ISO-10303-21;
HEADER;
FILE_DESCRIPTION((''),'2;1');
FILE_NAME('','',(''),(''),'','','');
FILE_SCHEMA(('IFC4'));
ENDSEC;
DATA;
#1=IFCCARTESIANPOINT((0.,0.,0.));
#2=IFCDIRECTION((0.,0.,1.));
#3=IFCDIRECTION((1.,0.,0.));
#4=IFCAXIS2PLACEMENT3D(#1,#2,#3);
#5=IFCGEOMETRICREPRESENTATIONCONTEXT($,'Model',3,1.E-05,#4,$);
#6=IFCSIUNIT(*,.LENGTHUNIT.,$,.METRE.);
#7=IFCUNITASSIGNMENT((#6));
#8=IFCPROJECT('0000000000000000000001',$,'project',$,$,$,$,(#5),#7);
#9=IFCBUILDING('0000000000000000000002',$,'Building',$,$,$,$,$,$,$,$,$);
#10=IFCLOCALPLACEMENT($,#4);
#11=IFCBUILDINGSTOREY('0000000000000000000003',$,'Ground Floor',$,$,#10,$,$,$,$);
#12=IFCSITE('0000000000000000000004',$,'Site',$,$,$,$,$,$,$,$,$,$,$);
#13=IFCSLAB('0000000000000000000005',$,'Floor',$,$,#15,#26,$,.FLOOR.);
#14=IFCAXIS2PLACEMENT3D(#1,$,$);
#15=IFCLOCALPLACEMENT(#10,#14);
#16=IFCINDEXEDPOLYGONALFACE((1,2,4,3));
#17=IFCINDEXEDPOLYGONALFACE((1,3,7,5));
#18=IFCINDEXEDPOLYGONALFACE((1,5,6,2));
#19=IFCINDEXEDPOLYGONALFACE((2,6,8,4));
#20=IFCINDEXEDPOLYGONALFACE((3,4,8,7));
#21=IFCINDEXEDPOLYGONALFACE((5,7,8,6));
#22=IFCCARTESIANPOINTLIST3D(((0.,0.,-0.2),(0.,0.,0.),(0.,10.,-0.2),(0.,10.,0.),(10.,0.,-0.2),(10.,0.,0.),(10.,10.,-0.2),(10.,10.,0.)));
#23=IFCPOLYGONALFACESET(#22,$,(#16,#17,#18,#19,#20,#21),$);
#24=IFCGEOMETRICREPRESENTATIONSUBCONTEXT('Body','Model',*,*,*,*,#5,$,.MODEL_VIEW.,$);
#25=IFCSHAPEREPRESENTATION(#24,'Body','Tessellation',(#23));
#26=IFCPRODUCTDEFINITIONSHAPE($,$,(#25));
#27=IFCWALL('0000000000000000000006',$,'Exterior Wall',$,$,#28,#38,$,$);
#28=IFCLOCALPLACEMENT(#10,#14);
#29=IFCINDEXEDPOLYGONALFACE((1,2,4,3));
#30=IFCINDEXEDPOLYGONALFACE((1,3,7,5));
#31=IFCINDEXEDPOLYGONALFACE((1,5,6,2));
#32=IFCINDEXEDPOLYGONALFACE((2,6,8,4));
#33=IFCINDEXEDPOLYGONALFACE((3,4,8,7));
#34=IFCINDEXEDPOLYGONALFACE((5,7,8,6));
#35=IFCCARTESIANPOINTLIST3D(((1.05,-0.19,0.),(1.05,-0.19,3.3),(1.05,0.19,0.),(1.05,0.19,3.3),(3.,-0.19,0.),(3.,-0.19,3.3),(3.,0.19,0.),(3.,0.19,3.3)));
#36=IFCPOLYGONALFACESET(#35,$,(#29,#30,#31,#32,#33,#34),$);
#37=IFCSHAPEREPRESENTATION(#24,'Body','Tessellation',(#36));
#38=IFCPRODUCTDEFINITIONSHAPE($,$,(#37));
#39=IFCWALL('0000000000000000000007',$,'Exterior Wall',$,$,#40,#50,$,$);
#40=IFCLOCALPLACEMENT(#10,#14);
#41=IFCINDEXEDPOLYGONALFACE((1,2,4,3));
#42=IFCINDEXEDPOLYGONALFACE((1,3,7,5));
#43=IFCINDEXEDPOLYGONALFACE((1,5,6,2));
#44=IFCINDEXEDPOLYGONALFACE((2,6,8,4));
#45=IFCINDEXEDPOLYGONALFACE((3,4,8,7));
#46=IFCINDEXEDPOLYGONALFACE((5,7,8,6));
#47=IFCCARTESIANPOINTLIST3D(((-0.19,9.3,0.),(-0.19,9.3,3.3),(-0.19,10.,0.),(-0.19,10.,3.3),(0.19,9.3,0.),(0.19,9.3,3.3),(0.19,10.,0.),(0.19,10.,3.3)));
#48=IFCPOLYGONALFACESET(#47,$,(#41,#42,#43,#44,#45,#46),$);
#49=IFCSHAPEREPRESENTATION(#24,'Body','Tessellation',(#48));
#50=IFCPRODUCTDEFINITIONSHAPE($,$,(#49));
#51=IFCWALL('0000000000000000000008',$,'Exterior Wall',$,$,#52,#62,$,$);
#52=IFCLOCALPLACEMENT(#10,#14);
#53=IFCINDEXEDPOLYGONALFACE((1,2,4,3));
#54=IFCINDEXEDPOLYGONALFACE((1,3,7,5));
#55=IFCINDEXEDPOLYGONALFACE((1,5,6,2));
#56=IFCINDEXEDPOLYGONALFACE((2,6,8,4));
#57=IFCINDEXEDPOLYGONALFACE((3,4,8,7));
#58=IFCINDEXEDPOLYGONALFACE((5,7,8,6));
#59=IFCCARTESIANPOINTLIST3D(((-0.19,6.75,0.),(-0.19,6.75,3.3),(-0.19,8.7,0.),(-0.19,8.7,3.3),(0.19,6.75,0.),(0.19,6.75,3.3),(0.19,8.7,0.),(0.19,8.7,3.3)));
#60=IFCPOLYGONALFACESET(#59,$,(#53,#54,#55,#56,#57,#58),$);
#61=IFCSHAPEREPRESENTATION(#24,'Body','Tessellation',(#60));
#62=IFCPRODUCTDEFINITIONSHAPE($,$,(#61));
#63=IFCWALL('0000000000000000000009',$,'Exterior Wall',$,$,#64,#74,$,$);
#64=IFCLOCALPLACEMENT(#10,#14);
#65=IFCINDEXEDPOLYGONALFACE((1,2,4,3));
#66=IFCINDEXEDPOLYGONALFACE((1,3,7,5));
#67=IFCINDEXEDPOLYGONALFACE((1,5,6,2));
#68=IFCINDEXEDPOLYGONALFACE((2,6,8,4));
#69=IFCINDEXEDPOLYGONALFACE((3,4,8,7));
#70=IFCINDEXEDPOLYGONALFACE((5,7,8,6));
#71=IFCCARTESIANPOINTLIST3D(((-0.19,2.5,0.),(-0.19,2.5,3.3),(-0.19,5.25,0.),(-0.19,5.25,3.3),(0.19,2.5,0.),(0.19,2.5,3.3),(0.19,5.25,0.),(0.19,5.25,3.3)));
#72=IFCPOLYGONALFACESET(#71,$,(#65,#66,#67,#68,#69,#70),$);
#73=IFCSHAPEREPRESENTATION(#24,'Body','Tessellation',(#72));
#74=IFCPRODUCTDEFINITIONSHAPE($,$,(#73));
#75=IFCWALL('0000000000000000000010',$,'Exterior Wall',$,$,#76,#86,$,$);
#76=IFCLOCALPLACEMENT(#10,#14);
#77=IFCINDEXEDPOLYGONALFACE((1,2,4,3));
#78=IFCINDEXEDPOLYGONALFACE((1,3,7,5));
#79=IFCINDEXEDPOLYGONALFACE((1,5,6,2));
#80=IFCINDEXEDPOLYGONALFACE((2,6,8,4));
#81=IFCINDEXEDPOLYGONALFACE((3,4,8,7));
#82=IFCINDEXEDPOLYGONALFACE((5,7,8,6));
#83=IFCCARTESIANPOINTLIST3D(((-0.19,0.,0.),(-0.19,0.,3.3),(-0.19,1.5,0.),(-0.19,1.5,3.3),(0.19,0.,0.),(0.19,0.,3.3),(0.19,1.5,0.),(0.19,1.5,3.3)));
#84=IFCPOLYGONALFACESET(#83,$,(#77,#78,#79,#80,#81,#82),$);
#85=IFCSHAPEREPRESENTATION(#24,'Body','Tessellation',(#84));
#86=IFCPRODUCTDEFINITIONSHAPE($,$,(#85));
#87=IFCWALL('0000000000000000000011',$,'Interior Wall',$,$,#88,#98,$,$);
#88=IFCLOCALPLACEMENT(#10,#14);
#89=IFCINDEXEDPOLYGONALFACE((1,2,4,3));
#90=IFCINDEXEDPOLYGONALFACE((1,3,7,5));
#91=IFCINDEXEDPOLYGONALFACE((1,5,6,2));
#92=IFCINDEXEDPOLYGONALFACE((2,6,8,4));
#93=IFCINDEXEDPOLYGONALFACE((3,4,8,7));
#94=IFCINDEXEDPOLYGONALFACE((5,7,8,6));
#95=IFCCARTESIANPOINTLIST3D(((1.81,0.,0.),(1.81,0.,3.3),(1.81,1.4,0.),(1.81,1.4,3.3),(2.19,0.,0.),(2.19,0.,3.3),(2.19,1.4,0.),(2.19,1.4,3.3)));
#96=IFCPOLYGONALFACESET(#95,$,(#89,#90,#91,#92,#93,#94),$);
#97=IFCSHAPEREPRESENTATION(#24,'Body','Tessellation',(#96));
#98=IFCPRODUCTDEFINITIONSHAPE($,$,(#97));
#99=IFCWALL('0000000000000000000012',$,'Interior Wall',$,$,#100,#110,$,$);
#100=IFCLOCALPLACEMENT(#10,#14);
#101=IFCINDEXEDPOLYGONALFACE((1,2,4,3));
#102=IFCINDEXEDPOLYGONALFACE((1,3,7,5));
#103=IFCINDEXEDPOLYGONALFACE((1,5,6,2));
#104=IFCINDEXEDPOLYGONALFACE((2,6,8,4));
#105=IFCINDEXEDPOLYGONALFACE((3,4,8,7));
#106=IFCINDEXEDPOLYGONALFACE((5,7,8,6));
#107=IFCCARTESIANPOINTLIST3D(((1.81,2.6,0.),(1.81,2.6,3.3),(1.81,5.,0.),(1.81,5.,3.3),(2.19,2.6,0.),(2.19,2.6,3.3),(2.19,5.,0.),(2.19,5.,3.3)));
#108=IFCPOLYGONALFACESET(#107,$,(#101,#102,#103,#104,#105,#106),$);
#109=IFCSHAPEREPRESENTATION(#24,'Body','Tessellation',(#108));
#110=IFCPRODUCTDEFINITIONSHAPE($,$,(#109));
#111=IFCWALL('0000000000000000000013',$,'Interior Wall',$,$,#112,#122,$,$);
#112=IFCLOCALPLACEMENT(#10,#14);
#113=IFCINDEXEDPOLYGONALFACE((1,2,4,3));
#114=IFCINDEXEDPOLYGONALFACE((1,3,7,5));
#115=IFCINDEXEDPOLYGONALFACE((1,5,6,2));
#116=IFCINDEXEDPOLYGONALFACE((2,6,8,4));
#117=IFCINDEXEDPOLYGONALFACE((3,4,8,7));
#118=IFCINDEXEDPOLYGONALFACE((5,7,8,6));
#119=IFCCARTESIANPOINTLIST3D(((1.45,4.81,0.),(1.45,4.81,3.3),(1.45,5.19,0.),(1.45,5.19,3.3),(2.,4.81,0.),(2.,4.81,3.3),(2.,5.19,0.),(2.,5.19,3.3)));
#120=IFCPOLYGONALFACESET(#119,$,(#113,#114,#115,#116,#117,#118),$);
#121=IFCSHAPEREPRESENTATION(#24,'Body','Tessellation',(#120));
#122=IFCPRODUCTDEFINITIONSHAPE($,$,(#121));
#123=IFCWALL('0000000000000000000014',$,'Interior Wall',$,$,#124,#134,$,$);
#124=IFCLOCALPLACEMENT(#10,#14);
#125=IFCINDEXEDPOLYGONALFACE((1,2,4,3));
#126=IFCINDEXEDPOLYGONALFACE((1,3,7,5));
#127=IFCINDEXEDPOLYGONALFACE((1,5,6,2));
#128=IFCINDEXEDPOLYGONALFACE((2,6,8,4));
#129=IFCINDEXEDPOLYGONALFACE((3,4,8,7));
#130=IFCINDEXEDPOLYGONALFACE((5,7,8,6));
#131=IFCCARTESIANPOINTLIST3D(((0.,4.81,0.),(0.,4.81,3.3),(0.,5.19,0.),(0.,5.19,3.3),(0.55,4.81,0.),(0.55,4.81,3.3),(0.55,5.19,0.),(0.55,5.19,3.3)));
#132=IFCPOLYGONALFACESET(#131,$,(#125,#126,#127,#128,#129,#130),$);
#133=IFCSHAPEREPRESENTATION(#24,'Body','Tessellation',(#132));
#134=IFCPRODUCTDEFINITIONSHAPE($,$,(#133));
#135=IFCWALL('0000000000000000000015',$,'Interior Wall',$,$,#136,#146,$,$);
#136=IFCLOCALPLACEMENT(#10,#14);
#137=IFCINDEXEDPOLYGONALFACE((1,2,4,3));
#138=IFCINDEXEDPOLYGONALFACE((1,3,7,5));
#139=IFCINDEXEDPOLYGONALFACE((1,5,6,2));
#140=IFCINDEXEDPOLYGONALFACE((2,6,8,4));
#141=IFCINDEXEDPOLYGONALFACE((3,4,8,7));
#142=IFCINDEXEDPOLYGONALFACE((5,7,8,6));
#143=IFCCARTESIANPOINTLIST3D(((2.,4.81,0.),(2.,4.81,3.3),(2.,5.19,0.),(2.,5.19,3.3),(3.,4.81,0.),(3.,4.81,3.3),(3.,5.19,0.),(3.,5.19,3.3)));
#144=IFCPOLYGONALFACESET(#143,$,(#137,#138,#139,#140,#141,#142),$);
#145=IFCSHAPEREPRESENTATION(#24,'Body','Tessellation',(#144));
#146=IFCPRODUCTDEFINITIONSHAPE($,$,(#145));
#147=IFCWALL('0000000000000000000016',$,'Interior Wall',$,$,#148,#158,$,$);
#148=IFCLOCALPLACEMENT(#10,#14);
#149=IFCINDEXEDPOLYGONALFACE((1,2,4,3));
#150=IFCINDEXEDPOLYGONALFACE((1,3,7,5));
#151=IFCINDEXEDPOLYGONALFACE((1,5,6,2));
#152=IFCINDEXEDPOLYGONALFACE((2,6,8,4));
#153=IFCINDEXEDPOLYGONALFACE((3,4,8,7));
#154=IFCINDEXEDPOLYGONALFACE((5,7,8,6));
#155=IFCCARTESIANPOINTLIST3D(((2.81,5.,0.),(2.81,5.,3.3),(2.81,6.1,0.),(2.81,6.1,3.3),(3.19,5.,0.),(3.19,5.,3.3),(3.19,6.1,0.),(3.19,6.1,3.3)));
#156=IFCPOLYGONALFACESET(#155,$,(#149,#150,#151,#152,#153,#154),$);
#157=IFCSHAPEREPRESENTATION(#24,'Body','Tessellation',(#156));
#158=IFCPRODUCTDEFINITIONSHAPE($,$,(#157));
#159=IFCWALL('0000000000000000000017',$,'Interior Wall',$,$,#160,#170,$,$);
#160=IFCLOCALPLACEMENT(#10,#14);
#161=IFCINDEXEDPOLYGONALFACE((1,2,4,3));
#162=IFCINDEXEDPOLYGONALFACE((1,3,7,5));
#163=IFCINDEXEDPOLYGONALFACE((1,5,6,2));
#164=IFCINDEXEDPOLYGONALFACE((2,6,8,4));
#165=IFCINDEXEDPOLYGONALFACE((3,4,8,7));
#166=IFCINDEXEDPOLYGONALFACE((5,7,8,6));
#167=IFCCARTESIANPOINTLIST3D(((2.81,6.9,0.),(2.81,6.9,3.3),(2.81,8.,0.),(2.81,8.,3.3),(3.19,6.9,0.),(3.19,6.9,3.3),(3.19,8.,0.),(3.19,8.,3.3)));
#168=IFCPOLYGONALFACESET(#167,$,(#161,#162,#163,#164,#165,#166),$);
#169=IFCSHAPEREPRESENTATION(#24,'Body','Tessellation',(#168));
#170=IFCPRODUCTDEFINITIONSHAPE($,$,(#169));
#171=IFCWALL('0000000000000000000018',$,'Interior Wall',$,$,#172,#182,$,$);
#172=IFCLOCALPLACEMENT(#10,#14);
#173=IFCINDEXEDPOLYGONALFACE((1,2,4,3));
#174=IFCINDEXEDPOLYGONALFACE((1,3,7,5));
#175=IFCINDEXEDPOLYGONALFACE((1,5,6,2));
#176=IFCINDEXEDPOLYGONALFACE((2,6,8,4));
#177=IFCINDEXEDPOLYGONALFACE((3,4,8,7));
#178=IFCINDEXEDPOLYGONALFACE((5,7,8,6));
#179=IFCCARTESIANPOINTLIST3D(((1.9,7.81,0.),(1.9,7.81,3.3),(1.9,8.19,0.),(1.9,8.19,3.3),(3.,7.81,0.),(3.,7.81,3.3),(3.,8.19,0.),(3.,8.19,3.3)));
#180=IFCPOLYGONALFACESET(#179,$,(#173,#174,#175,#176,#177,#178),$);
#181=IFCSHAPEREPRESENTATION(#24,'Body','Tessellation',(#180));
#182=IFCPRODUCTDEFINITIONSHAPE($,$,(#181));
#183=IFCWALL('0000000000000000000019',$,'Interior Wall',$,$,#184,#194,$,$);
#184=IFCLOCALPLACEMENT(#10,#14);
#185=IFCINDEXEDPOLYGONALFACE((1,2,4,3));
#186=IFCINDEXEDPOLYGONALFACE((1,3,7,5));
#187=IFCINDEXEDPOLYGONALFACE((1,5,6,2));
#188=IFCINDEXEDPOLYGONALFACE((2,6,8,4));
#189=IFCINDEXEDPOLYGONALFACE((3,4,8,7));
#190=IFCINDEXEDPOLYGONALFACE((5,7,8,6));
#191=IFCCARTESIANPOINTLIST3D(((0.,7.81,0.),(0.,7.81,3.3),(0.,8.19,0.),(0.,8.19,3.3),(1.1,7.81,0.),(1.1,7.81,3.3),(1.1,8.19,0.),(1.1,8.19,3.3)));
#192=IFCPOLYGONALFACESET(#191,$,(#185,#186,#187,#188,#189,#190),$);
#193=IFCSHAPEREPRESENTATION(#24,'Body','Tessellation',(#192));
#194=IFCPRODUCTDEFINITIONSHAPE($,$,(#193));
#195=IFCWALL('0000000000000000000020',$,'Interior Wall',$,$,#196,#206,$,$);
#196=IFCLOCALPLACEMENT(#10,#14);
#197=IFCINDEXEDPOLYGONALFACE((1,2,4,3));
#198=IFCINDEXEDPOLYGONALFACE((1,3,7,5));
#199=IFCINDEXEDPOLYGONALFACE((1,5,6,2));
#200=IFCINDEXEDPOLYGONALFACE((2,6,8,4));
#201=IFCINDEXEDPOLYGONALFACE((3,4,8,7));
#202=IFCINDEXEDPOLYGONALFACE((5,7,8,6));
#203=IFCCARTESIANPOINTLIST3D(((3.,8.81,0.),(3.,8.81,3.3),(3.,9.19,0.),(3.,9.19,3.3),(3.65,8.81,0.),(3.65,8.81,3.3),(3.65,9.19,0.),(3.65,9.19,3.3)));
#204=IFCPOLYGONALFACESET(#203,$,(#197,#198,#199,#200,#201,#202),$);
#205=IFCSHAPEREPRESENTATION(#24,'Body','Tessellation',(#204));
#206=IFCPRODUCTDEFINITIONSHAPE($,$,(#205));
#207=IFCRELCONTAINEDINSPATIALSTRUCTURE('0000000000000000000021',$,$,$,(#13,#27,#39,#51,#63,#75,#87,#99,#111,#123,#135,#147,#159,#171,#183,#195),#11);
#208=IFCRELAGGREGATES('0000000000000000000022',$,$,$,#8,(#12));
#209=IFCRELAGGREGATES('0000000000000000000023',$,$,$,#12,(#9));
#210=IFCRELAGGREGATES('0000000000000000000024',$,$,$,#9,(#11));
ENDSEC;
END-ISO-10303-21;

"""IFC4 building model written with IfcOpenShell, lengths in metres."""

from ifc_helpers import new_model, si_unit, frame, origin_with_axes, place, context, subcontext, project, spatial, indexed_curve, outline, extrude, element, save


model = new_model("IFC4")

# Units and contexts
model_context = context("Model", 3, precision=1e-05, world=origin_with_axes())
body_context = subcontext(model_context, "Body", "Model", "MODEL_VIEW")
ifc_project = project(units=[si_unit("LENGTHUNIT", "METRE")], contexts=[model_context])

# Site, building, storey
site = spatial("IfcSite", under=ifc_project, Name="Site")
building = spatial("IfcBuilding", under=site, Name="Building")
storey_placement = place(None, origin_with_axes())
storey = spatial("IfcBuildingStorey", under=building, at=storey_placement, Name="Ground Floor")

# Slab
slab_placement = place(storey_placement, frame((0.0, 0.0, -0.2), z_axis=(0.0, 0.0, 1.0), x_axis=(1.0, 0.0, 0.0)))
element("IfcSlab", 1, at=slab_placement, inside=storey, Name="Floor", PredefinedType="FLOOR", context=body_context, shape_type="SweptSolid", body=[
    extrude(outline(indexed_curve([(0.0, 0.0), (10.0, 0.0), (10.0, 10.0), (0.0, 10.0)])), None, (0.0, 0.0, 1.0), 0.2),
])

# Walls
wall_1_placement = place(storey_placement, frame((1.05, 0.0, 0.0), z_axis=(0.0, 0.0, 1.0), x_axis=(1.0, 0.0, 0.0)))
element("IfcWall", 2, at=wall_1_placement, inside=storey, Name="Exterior Wall", context=body_context, shape_type="SweptSolid", body=[
    extrude(outline(indexed_curve([(0.0, 0.0), (0.0, 0.38), (1.95, 0.38), (1.95, 0.0), (0.0, 0.0)], self_intersect=False)), frame((0.0, -0.19, 0.0), z_axis=(0.0, 0.0, 1.0), x_axis=(1.0, 0.0, 0.0)), (0.0, 0.0, 1.0), 3.3),
])
wall_2_placement = place(storey_placement, frame((0.0, 10.0, 0.0), z_axis=(0.0, 0.0, 1.0), x_axis=(0.0, -1.0, 0.0)))
element("IfcWall", 3, at=wall_2_placement, inside=storey, Name="Exterior Wall", context=body_context, shape_type="SweptSolid", body=[
    extrude(outline(indexed_curve([(0.0, 0.0), (0.0, 0.38), (0.7, 0.38), (0.7, 0.0), (0.0, 0.0)], self_intersect=False)), frame((0.0, -0.19, 0.0), z_axis=(0.0, 0.0, 1.0), x_axis=(1.0, 0.0, 0.0)), (0.0, 0.0, 1.0), 3.3),
])
wall_3_placement = place(storey_placement, frame((0.0, 8.7, 0.0), z_axis=(0.0, 0.0, 1.0), x_axis=(0.0, -1.0, 0.0)))
element("IfcWall", 4, at=wall_3_placement, inside=storey, Name="Exterior Wall", context=body_context, shape_type="SweptSolid", body=[
    extrude(outline(indexed_curve([(0.0, 0.0), (0.0, 0.38), (1.95, 0.38), (1.95, 0.0), (0.0, 0.0)], self_intersect=False)), frame((0.0, -0.19, 0.0), z_axis=(0.0, 0.0, 1.0), x_axis=(1.0, 0.0, 0.0)), (0.0, 0.0, 1.0), 3.3),
])
wall_4_placement = place(storey_placement, frame((0.0, 5.25, 0.0), z_axis=(0.0, 0.0, 1.0), x_axis=(0.0, -1.0, 0.0)))
element("IfcWall", 5, at=wall_4_placement, inside=storey, Name="Exterior Wall", context=body_context, shape_type="SweptSolid", body=[
    extrude(outline(indexed_curve([(0.0, 0.0), (0.0, 0.38), (2.75, 0.38), (2.75, 0.0), (0.0, 0.0)], self_intersect=False)), frame((0.0, -0.19, 0.0), z_axis=(0.0, 0.0, 1.0), x_axis=(1.0, 0.0, 0.0)), (0.0, 0.0, 1.0), 3.3),
])
wall_5_placement = place(storey_placement, frame((0.0, 1.5, 0.0), z_axis=(0.0, 0.0, 1.0), x_axis=(0.0, -1.0, 0.0)))
element("IfcWall", 6, at=wall_5_placement, inside=storey, Name="Exterior Wall", context=body_context, shape_type="SweptSolid", body=[
    extrude(outline(indexed_curve([(0.0, 0.0), (0.0, 0.38), (1.5, 0.38), (1.5, 0.0), (0.0, 0.0)], self_intersect=False)), frame((0.0, -0.19, 0.0), z_axis=(0.0, 0.0, 1.0), x_axis=(1.0, 0.0, 0.0)), (0.0, 0.0, 1.0), 3.3),
])
wall_6_placement = place(storey_placement, frame((2.0, 0.0, 0.0), z_axis=(0.0, 0.0, 1.0), x_axis=(0.0, 1.0, 0.0)))
element("IfcWall", 7, at=wall_6_placement, inside=storey, Name="Interior Wall", context=body_context, shape_type="SweptSolid", body=[
    extrude(outline(indexed_curve([(0.0, 0.0), (0.0, 0.38), (1.4, 0.38), (1.4, 0.0), (0.0, 0.0)], self_intersect=False)), frame((0.0, -0.19, 0.0), z_axis=(0.0, 0.0, 1.0), x_axis=(1.0, 0.0, 0.0)), (0.0, 0.0, 1.0), 3.3),
])
wall_7_placement = place(storey_placement, frame((2.0, 2.6, 0.0), z_axis=(0.0, 0.0, 1.0), x_axis=(0.0, 1.0, 0.0)))
element("IfcWall", 8, at=wall_7_placement, inside=storey, Name="Interior Wall", context=body_context, shape_type="SweptSolid", body=[
    extrude(outline(indexed_curve([(0.0, 0.0), (0.0, 0.38), (2.4, 0.38), (2.4, 0.0), (0.0, 0.0)], self_intersect=False)), frame((0.0, -0.19, 0.0), z_axis=(0.0, 0.0, 1.0), x_axis=(1.0, 0.0, 0.0)), (0.0, 0.0, 1.0), 3.3),
])
for number, where, z_axis, x_axis, name in (
    (9, (2.0, 5.0, 0.0), (0.0, 0.0, 1.0), (-1.0, 0.0, 0.0), "Interior Wall"),
    (10, (0.55, 5.0, 0.0), (0.0, 0.0, 1.0), (-1.0, 0.0, 0.0), "Interior Wall"),
):
    element("IfcWall", number, at=place(storey_placement, frame(where, z_axis=z_axis, x_axis=x_axis)), inside=storey, Name=name, context=body_context, shape_type="SweptSolid", body=[
        extrude(outline(indexed_curve([(0.0, 0.0), (0.0, 0.38), (0.55, 0.38), (0.55, 0.0), (0.0, 0.0)], self_intersect=False)), frame((0.0, -0.19, 0.0), z_axis=(0.0, 0.0, 1.0), x_axis=(1.0, 0.0, 0.0)), (0.0, 0.0, 1.0), 3.3),
    ])
wall_8_placement = place(storey_placement, frame((3.0, 5.0, 0.0), z_axis=(0.0, 0.0, 1.0), x_axis=(-1.0, 0.0, 0.0)))
element("IfcWall", 11, at=wall_8_placement, inside=storey, Name="Interior Wall", context=body_context, shape_type="SweptSolid", body=[
    extrude(outline(indexed_curve([(0.0, 0.0), (0.0, 0.38), (1.0, 0.38), (1.0, 0.0), (0.0, 0.0)], self_intersect=False)), frame((0.0, -0.19, 0.0), z_axis=(0.0, 0.0, 1.0), x_axis=(1.0, 0.0, 0.0)), (0.0, 0.0, 1.0), 3.3),
])
for number, where, z_axis, x_axis, name in (
    (12, (3.0, 5.0, 0.0), (0.0, 0.0, 1.0), (0.0, 1.0, 0.0), "Interior Wall"),
    (13, (3.0, 6.9, 0.0), (0.0, 0.0, 1.0), (0.0, 1.0, 0.0), "Interior Wall"),
):
    element("IfcWall", number, at=place(storey_placement, frame(where, z_axis=z_axis, x_axis=x_axis)), inside=storey, Name=name, context=body_context, shape_type="SweptSolid", body=[
        extrude(outline(indexed_curve([(0.0, 0.0), (0.0, 0.38), (1.1, 0.38), (1.1, 0.0), (0.0, 0.0)], self_intersect=False)), frame((0.0, -0.19, 0.0), z_axis=(0.0, 0.0, 1.0), x_axis=(1.0, 0.0, 0.0)), (0.0, 0.0, 1.0), 3.3),
    ])
for number, where, z_axis, x_axis, name in (
    (14, (3.0, 8.0, 0.0), (0.0, 0.0, 1.0), (-1.0, 0.0, 0.0), "Interior Wall"),
    (15, (1.1, 8.0, 0.0), (0.0, 0.0, 1.0), (-1.0, 0.0, 0.0), "Interior Wall"),
):
    element("IfcWall", number, at=place(storey_placement, frame(where, z_axis=z_axis, x_axis=x_axis)), inside=storey, Name=name, context=body_context, shape_type="SweptSolid", body=[
        extrude(outline(indexed_curve([(0.0, 0.0), (0.0, 0.38), (1.1, 0.38), (1.1, 0.0), (0.0, 0.0)], self_intersect=False)), frame((0.0, -0.19, 0.0), z_axis=(0.0, 0.0, 1.0), x_axis=(1.0, 0.0, 0.0)), (0.0, 0.0, 1.0), 3.3),
    ])
wall_9_placement = place(storey_placement, frame((3.65, 9.0, 0.0), z_axis=(0.0, 0.0, 1.0), x_axis=(-1.0, 0.0, 0.0)))
element("IfcWall", 16, at=wall_9_placement, inside=storey, Name="Interior Wall", context=body_context, shape_type="SweptSolid", body=[
    extrude(outline(indexed_curve([(0.0, 0.0), (0.0, 0.38), (0.65, 0.38), (0.65, 0.0), (0.0, 0.0)], self_intersect=False)), frame((0.0, -0.19, 0.0), z_axis=(0.0, 0.0, 1.0), x_axis=(1.0, 0.0, 0.0)), (0.0, 0.0, 1.0), 3.3),
])

save(model, "model.ifc")
